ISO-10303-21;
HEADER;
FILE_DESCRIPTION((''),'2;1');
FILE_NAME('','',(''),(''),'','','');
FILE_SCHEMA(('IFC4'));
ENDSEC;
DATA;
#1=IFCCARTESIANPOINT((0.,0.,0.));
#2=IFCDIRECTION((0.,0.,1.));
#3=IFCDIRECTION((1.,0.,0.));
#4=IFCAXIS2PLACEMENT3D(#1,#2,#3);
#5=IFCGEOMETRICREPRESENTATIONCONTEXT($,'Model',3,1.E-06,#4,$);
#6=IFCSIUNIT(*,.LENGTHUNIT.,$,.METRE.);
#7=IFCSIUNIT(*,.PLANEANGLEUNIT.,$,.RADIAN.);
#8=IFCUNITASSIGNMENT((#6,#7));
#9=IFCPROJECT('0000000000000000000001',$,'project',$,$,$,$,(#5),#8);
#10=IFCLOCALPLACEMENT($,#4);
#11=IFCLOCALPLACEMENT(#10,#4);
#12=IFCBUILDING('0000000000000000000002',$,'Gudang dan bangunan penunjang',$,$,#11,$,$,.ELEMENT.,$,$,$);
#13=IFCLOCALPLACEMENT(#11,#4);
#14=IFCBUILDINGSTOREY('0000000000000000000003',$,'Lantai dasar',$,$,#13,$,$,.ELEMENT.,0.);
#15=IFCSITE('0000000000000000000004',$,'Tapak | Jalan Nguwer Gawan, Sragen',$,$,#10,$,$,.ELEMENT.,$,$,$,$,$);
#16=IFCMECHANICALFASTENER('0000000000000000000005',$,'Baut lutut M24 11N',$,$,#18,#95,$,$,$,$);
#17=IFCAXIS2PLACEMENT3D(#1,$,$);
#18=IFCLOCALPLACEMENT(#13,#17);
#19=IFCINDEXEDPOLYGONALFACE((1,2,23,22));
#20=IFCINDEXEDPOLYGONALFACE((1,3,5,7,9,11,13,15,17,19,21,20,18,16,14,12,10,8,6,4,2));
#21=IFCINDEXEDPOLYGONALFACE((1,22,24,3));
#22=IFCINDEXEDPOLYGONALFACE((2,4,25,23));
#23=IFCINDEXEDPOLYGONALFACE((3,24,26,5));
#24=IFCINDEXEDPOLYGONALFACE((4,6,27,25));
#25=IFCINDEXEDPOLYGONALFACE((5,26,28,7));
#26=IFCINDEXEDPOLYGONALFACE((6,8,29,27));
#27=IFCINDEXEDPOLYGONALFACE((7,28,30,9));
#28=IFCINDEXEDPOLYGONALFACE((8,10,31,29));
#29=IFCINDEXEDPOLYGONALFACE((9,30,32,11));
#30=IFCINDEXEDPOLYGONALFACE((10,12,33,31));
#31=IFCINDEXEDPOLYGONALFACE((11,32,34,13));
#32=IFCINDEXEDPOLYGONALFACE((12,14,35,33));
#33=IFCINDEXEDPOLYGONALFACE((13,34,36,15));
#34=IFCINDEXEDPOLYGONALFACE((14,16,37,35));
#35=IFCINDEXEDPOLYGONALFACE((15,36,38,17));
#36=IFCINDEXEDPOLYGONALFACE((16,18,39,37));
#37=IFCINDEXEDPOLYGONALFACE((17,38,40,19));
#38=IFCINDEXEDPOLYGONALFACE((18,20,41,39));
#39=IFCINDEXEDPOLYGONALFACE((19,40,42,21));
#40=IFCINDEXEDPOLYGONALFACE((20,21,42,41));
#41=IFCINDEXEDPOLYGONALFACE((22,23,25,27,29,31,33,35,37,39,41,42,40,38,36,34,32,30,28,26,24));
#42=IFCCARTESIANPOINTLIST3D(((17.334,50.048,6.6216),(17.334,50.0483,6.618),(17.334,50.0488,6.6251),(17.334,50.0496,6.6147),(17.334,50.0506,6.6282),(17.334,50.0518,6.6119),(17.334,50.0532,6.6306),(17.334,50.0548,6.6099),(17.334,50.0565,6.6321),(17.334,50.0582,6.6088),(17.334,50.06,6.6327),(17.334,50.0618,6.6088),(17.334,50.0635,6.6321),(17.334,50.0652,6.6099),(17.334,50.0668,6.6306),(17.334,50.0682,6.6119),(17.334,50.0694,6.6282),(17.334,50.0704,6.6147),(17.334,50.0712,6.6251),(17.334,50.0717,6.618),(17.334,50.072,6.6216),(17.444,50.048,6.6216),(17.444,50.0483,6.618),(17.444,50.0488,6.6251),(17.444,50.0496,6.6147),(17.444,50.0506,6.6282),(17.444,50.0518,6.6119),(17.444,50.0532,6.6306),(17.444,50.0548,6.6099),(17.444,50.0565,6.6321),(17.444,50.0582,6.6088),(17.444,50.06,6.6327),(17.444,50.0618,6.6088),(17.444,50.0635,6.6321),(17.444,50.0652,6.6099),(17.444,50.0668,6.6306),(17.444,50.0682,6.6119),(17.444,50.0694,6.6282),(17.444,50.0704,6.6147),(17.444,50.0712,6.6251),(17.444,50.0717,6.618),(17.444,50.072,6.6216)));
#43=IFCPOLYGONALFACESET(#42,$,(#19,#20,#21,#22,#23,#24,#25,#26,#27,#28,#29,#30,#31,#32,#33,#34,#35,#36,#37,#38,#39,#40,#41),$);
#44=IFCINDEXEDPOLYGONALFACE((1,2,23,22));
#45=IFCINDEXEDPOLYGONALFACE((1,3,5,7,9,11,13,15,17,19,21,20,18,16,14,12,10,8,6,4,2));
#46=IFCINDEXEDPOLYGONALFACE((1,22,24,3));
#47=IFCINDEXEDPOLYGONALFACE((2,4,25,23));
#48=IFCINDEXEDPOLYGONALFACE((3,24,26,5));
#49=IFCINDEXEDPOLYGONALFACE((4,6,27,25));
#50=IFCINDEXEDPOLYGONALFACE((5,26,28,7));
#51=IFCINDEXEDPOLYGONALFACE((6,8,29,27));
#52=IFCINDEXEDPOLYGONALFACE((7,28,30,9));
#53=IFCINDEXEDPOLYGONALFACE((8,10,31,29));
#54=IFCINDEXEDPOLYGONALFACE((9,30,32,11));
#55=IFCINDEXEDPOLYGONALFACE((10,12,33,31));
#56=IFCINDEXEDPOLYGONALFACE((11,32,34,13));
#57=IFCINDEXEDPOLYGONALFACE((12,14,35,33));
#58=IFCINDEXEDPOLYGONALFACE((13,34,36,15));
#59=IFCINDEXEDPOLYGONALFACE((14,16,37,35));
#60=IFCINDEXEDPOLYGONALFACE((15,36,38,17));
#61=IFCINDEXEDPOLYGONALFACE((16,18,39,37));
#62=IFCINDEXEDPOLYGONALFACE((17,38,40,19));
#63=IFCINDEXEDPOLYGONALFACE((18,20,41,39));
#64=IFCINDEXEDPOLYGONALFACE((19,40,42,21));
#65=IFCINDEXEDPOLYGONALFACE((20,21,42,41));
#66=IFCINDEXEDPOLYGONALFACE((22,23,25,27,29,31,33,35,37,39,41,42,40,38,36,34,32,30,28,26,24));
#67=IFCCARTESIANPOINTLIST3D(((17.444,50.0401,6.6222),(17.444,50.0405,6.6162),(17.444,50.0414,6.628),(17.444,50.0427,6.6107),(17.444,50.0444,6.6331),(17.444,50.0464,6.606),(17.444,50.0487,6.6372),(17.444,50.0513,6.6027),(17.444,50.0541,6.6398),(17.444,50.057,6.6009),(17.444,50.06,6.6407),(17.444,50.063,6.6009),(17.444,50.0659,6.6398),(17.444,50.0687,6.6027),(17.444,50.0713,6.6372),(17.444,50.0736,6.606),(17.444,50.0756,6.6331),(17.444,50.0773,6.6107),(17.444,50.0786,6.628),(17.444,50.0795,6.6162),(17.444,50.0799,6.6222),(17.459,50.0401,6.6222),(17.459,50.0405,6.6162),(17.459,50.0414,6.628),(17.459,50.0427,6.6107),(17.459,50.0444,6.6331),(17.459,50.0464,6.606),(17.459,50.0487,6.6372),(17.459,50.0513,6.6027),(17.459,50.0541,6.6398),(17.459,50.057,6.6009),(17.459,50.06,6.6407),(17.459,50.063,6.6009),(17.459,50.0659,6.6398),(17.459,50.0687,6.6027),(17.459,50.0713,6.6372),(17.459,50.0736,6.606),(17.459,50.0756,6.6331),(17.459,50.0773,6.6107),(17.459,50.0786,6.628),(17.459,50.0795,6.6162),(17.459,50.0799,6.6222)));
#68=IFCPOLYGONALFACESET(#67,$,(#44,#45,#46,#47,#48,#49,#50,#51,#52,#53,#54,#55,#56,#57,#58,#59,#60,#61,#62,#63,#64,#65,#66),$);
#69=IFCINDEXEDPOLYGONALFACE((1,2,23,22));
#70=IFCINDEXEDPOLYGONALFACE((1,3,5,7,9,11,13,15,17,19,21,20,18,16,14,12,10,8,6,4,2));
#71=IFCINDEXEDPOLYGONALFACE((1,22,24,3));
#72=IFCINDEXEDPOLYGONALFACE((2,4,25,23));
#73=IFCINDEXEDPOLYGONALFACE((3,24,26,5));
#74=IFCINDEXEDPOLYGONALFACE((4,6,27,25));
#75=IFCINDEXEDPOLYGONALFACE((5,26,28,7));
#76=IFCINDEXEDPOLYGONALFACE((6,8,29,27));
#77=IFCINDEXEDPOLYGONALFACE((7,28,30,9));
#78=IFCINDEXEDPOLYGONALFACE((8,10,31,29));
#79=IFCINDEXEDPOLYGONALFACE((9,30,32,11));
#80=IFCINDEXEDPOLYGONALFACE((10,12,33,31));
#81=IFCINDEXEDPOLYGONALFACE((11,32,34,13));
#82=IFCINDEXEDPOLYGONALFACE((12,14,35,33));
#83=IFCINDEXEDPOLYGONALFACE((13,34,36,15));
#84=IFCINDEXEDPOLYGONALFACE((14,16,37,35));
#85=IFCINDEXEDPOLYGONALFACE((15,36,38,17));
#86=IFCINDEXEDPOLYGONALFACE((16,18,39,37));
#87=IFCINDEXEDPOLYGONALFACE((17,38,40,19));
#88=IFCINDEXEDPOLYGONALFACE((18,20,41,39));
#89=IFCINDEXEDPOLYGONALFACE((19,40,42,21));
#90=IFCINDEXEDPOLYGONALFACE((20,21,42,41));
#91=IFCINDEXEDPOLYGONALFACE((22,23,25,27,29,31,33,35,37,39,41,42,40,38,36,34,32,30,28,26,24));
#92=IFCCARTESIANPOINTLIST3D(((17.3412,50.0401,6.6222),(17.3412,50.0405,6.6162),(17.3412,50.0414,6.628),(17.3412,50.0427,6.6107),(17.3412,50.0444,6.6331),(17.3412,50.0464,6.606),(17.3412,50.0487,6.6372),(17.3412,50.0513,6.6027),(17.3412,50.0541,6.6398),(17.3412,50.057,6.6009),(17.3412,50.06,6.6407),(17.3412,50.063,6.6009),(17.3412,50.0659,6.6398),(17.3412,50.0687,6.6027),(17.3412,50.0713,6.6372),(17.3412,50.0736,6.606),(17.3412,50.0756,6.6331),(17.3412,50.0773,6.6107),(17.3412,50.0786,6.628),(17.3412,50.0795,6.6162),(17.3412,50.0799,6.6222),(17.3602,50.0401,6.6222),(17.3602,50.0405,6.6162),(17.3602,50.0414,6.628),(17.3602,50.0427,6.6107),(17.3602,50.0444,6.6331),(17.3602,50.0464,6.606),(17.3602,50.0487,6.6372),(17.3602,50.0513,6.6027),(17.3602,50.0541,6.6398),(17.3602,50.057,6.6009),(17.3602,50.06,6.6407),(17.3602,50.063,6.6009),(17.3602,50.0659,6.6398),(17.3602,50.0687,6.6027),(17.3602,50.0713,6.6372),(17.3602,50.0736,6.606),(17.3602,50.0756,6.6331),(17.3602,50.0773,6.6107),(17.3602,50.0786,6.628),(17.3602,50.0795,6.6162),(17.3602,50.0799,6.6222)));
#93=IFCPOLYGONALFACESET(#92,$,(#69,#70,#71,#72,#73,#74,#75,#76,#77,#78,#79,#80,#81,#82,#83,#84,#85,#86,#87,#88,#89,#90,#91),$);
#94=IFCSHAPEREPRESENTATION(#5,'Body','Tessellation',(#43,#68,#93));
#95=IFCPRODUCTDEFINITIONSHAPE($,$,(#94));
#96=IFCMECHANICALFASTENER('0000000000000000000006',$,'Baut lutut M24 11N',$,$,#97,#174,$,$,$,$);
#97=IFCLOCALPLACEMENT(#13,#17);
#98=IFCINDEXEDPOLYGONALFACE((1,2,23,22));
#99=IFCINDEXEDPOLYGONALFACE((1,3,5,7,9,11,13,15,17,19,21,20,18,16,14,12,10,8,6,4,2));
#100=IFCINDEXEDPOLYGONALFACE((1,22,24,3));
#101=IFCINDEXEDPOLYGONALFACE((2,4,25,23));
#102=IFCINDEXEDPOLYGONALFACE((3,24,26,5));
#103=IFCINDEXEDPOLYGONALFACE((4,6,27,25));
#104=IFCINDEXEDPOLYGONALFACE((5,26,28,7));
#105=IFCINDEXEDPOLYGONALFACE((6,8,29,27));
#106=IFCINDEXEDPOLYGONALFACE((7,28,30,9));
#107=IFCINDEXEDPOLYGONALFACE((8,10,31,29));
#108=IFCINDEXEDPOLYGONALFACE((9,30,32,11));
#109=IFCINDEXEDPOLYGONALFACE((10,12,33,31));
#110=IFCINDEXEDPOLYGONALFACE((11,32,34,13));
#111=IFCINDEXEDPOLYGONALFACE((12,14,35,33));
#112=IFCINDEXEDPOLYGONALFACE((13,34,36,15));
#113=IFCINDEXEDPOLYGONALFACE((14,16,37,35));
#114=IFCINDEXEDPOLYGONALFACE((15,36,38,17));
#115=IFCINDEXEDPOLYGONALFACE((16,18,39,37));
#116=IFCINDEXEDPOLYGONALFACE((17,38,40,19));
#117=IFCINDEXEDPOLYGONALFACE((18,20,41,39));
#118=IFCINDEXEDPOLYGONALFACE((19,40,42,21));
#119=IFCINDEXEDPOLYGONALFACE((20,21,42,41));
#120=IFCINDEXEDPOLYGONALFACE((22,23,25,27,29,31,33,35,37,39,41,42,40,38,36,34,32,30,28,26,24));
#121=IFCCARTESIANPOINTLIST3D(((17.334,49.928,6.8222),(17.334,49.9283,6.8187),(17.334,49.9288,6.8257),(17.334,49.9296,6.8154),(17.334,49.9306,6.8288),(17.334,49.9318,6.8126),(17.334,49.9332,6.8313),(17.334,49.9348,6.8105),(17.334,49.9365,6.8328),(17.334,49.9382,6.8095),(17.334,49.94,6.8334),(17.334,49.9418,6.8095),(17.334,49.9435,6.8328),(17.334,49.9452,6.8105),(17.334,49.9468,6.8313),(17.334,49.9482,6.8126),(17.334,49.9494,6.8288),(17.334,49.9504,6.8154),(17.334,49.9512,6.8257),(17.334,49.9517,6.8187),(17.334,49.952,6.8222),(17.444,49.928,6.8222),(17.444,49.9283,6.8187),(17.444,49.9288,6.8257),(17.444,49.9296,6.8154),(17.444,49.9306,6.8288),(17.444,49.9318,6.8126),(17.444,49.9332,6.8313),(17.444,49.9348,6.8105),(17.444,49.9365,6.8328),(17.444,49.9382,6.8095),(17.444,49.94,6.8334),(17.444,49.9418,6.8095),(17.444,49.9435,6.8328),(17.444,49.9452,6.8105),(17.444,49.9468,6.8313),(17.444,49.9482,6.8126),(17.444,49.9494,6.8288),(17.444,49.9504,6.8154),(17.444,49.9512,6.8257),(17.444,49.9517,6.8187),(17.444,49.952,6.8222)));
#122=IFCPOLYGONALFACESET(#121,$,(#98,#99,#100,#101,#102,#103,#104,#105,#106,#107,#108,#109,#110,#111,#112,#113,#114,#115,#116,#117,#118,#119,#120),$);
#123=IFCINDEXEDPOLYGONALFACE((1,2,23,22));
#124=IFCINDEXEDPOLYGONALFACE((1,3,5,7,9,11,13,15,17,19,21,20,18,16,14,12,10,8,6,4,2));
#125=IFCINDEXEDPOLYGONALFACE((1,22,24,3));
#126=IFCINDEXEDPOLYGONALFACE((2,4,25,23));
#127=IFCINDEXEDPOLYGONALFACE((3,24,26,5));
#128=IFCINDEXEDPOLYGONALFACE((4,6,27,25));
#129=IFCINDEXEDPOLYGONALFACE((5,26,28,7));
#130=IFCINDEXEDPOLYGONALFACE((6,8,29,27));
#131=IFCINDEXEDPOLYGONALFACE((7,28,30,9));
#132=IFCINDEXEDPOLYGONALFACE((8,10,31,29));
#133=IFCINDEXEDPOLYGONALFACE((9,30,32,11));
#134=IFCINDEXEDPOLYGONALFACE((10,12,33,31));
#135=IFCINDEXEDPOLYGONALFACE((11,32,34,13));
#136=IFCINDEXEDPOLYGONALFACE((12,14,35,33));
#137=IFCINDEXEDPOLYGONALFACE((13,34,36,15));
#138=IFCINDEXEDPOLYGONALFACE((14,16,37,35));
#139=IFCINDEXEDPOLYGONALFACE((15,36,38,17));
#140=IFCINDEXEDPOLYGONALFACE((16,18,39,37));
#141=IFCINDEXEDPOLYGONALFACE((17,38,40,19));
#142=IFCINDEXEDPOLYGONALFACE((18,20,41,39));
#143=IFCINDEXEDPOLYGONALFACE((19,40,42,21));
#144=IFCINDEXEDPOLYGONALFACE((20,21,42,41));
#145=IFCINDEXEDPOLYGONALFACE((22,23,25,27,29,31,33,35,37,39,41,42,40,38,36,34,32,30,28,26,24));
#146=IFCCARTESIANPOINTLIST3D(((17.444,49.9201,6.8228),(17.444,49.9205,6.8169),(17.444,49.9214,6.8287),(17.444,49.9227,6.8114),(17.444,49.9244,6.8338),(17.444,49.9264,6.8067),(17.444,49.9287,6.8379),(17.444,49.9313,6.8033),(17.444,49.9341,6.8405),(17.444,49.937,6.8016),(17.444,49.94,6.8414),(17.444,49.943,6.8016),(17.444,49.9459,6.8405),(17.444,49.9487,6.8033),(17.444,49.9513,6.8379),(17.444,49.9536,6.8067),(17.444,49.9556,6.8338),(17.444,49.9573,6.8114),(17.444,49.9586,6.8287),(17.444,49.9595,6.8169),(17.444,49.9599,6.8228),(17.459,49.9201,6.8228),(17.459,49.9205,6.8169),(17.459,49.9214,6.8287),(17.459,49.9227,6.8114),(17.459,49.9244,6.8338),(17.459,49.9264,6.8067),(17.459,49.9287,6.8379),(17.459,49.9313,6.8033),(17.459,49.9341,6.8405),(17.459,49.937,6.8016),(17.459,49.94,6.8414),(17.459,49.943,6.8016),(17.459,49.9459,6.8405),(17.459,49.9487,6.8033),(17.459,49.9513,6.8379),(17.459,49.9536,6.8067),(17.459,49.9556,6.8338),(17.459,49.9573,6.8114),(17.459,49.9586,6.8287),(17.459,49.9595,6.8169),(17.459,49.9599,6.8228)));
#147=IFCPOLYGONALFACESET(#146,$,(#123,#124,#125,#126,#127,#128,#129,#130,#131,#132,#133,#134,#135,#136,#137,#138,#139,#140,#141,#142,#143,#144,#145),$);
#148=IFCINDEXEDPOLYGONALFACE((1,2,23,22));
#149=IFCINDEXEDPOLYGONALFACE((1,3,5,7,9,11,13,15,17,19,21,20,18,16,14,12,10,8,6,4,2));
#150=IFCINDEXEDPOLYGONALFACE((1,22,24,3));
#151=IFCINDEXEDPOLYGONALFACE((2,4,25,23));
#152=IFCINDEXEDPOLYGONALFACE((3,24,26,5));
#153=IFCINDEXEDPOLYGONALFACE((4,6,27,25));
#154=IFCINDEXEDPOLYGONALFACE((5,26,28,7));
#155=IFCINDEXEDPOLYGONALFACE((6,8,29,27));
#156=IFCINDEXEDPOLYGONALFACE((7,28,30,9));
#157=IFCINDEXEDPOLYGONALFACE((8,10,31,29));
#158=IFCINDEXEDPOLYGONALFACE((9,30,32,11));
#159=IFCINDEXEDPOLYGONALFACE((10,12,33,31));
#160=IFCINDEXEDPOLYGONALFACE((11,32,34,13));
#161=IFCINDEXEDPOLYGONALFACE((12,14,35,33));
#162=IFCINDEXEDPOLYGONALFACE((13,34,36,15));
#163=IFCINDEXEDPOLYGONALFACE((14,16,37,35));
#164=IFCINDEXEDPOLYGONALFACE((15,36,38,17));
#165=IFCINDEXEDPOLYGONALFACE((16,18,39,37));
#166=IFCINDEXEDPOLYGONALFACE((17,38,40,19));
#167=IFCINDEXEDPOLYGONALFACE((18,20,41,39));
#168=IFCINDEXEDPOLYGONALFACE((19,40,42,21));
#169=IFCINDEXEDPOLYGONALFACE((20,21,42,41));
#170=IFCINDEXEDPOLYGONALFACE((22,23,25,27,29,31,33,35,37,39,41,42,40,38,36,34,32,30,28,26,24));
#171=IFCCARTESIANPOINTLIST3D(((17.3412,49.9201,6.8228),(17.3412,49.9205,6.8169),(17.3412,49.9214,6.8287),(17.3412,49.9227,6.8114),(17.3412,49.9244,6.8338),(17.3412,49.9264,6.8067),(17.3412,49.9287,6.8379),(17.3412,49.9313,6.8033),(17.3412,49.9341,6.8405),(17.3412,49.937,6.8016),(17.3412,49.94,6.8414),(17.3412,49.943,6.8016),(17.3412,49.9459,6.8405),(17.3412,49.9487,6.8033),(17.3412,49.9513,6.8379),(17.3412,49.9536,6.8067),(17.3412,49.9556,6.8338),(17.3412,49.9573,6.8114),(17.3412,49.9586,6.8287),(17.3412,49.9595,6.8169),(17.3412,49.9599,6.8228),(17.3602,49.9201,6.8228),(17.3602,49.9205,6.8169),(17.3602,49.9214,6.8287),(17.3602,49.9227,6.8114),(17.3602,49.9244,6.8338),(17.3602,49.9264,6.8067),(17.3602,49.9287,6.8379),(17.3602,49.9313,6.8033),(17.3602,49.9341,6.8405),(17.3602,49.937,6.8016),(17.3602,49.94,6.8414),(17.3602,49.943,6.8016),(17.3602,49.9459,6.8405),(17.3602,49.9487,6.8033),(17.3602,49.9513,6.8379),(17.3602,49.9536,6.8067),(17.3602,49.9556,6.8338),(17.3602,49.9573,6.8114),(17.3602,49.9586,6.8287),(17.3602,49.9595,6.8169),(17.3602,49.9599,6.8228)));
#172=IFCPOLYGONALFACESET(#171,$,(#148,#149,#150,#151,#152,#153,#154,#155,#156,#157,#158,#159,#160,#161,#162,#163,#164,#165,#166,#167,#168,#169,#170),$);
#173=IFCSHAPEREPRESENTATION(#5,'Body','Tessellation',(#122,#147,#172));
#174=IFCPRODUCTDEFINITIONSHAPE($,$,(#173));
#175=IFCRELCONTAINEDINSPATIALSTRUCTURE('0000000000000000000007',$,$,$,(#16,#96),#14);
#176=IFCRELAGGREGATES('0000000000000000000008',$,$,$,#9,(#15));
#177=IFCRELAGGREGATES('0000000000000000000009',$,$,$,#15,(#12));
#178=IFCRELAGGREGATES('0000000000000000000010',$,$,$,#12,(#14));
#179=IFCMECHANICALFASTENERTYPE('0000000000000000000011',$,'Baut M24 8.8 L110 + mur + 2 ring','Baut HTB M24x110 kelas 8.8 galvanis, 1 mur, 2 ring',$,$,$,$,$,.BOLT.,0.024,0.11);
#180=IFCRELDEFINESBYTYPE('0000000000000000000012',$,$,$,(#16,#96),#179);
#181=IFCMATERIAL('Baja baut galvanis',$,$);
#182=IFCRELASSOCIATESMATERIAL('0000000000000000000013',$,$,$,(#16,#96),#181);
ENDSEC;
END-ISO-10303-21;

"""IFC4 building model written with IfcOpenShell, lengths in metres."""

from ifc_helpers import new_model, si_unit, frame, origin_with_axes, place, context, project, spatial, circle, extrude, source, transform, mapped, material, type_object, type_shapes, element, save


model = new_model("IFC4")

# Units and contexts
model_context = context("Model", 3, precision=1e-06, world=origin_with_axes())
ifc_project = project(units=[si_unit("LENGTHUNIT", "METRE"), si_unit("PLANEANGLEUNIT", "RADIAN")], contexts=[model_context])

# Site, building, storey
site_placement = place(None, origin_with_axes())
site = spatial("IfcSite", under=ifc_project, at=site_placement, Name="Tapak | Jalan Nguwer Gawan, Sragen", CompositionType="ELEMENT")
building_placement = place(site_placement, origin_with_axes())
building = spatial("IfcBuilding", under=site, at=building_placement, Name="Gudang dan bangunan penunjang", CompositionType="ELEMENT")
storey_placement = place(building_placement, origin_with_axes())
storey = spatial("IfcBuildingStorey", under=building, at=storey_placement, Name="Lantai dasar", CompositionType="ELEMENT", Elevation=0.0)

# Shared definitions
placement = place(None, origin_with_axes())

# Mechanical fasteners
ifc_material_1 = material(Name="Baja baut galvanis")
mechanical_fastener_type_1 = type_object("IfcMechanicalFastenerType", Name="Baut M24 8.8 L110 + mur + 2 ring", Description="Baut HTB M24x110 kelas 8.8 galvanis, 1 mur, 2 ring", NominalDiameter=0.024, NominalLength=0.11, PredefinedType="BOLT")
shared_shape_1 = source(origin_with_axes(), model_context, "Body", "SweptSolid", [
    extrude(circle(Radius=0.012), origin_with_axes(), (0.0, 0.0, 1.0), 0.11),
    extrude(circle(Radius=0.02), frame((0.0, 0.0, -0.015), z_axis=(0.0, 0.0, 1.0), x_axis=(1.0, 0.0, 0.0)), (0.0, 0.0, 1.0), 0.015),
    extrude(circle(Radius=0.02), frame((0.0, 0.0, 0.0838), z_axis=(0.0, 0.0, 1.0), x_axis=(1.0, 0.0, 0.0)), (0.0, 0.0, 1.0), 0.019),
])
type_shapes(mechanical_fastener_type_1, [shared_shape_1])
element("IfcMechanicalFastener", 1, at=placement, inside=storey, type_object=mechanical_fastener_type_1, material=ifc_material_1, Name="Baut lutut M24 11N", context=model_context, shape_type="MappedRepresentation", body=[
    mapped(shared_shape_1, transform((17.444, 50.06, 6.6207), x_axis=(0.0, 0.0, 1.0), y_axis=(0.0, 1.0, 0.0), z_axis=(-1.0, 0.0, 0.0), scale=1.0)),
])
element("IfcMechanicalFastener", 2, at=placement, inside=storey, type_object=mechanical_fastener_type_1, material=ifc_material_1, Name="Baut lutut M24 11N", context=model_context, shape_type="MappedRepresentation", body=[
    mapped(shared_shape_1, transform((17.444, 49.94, 6.8213), x_axis=(0.0, 0.0, 1.0), y_axis=(0.0, 1.0, 0.0), z_axis=(-1.0, 0.0, 0.0), scale=1.0)),
])

save(model, "model.ifc")
